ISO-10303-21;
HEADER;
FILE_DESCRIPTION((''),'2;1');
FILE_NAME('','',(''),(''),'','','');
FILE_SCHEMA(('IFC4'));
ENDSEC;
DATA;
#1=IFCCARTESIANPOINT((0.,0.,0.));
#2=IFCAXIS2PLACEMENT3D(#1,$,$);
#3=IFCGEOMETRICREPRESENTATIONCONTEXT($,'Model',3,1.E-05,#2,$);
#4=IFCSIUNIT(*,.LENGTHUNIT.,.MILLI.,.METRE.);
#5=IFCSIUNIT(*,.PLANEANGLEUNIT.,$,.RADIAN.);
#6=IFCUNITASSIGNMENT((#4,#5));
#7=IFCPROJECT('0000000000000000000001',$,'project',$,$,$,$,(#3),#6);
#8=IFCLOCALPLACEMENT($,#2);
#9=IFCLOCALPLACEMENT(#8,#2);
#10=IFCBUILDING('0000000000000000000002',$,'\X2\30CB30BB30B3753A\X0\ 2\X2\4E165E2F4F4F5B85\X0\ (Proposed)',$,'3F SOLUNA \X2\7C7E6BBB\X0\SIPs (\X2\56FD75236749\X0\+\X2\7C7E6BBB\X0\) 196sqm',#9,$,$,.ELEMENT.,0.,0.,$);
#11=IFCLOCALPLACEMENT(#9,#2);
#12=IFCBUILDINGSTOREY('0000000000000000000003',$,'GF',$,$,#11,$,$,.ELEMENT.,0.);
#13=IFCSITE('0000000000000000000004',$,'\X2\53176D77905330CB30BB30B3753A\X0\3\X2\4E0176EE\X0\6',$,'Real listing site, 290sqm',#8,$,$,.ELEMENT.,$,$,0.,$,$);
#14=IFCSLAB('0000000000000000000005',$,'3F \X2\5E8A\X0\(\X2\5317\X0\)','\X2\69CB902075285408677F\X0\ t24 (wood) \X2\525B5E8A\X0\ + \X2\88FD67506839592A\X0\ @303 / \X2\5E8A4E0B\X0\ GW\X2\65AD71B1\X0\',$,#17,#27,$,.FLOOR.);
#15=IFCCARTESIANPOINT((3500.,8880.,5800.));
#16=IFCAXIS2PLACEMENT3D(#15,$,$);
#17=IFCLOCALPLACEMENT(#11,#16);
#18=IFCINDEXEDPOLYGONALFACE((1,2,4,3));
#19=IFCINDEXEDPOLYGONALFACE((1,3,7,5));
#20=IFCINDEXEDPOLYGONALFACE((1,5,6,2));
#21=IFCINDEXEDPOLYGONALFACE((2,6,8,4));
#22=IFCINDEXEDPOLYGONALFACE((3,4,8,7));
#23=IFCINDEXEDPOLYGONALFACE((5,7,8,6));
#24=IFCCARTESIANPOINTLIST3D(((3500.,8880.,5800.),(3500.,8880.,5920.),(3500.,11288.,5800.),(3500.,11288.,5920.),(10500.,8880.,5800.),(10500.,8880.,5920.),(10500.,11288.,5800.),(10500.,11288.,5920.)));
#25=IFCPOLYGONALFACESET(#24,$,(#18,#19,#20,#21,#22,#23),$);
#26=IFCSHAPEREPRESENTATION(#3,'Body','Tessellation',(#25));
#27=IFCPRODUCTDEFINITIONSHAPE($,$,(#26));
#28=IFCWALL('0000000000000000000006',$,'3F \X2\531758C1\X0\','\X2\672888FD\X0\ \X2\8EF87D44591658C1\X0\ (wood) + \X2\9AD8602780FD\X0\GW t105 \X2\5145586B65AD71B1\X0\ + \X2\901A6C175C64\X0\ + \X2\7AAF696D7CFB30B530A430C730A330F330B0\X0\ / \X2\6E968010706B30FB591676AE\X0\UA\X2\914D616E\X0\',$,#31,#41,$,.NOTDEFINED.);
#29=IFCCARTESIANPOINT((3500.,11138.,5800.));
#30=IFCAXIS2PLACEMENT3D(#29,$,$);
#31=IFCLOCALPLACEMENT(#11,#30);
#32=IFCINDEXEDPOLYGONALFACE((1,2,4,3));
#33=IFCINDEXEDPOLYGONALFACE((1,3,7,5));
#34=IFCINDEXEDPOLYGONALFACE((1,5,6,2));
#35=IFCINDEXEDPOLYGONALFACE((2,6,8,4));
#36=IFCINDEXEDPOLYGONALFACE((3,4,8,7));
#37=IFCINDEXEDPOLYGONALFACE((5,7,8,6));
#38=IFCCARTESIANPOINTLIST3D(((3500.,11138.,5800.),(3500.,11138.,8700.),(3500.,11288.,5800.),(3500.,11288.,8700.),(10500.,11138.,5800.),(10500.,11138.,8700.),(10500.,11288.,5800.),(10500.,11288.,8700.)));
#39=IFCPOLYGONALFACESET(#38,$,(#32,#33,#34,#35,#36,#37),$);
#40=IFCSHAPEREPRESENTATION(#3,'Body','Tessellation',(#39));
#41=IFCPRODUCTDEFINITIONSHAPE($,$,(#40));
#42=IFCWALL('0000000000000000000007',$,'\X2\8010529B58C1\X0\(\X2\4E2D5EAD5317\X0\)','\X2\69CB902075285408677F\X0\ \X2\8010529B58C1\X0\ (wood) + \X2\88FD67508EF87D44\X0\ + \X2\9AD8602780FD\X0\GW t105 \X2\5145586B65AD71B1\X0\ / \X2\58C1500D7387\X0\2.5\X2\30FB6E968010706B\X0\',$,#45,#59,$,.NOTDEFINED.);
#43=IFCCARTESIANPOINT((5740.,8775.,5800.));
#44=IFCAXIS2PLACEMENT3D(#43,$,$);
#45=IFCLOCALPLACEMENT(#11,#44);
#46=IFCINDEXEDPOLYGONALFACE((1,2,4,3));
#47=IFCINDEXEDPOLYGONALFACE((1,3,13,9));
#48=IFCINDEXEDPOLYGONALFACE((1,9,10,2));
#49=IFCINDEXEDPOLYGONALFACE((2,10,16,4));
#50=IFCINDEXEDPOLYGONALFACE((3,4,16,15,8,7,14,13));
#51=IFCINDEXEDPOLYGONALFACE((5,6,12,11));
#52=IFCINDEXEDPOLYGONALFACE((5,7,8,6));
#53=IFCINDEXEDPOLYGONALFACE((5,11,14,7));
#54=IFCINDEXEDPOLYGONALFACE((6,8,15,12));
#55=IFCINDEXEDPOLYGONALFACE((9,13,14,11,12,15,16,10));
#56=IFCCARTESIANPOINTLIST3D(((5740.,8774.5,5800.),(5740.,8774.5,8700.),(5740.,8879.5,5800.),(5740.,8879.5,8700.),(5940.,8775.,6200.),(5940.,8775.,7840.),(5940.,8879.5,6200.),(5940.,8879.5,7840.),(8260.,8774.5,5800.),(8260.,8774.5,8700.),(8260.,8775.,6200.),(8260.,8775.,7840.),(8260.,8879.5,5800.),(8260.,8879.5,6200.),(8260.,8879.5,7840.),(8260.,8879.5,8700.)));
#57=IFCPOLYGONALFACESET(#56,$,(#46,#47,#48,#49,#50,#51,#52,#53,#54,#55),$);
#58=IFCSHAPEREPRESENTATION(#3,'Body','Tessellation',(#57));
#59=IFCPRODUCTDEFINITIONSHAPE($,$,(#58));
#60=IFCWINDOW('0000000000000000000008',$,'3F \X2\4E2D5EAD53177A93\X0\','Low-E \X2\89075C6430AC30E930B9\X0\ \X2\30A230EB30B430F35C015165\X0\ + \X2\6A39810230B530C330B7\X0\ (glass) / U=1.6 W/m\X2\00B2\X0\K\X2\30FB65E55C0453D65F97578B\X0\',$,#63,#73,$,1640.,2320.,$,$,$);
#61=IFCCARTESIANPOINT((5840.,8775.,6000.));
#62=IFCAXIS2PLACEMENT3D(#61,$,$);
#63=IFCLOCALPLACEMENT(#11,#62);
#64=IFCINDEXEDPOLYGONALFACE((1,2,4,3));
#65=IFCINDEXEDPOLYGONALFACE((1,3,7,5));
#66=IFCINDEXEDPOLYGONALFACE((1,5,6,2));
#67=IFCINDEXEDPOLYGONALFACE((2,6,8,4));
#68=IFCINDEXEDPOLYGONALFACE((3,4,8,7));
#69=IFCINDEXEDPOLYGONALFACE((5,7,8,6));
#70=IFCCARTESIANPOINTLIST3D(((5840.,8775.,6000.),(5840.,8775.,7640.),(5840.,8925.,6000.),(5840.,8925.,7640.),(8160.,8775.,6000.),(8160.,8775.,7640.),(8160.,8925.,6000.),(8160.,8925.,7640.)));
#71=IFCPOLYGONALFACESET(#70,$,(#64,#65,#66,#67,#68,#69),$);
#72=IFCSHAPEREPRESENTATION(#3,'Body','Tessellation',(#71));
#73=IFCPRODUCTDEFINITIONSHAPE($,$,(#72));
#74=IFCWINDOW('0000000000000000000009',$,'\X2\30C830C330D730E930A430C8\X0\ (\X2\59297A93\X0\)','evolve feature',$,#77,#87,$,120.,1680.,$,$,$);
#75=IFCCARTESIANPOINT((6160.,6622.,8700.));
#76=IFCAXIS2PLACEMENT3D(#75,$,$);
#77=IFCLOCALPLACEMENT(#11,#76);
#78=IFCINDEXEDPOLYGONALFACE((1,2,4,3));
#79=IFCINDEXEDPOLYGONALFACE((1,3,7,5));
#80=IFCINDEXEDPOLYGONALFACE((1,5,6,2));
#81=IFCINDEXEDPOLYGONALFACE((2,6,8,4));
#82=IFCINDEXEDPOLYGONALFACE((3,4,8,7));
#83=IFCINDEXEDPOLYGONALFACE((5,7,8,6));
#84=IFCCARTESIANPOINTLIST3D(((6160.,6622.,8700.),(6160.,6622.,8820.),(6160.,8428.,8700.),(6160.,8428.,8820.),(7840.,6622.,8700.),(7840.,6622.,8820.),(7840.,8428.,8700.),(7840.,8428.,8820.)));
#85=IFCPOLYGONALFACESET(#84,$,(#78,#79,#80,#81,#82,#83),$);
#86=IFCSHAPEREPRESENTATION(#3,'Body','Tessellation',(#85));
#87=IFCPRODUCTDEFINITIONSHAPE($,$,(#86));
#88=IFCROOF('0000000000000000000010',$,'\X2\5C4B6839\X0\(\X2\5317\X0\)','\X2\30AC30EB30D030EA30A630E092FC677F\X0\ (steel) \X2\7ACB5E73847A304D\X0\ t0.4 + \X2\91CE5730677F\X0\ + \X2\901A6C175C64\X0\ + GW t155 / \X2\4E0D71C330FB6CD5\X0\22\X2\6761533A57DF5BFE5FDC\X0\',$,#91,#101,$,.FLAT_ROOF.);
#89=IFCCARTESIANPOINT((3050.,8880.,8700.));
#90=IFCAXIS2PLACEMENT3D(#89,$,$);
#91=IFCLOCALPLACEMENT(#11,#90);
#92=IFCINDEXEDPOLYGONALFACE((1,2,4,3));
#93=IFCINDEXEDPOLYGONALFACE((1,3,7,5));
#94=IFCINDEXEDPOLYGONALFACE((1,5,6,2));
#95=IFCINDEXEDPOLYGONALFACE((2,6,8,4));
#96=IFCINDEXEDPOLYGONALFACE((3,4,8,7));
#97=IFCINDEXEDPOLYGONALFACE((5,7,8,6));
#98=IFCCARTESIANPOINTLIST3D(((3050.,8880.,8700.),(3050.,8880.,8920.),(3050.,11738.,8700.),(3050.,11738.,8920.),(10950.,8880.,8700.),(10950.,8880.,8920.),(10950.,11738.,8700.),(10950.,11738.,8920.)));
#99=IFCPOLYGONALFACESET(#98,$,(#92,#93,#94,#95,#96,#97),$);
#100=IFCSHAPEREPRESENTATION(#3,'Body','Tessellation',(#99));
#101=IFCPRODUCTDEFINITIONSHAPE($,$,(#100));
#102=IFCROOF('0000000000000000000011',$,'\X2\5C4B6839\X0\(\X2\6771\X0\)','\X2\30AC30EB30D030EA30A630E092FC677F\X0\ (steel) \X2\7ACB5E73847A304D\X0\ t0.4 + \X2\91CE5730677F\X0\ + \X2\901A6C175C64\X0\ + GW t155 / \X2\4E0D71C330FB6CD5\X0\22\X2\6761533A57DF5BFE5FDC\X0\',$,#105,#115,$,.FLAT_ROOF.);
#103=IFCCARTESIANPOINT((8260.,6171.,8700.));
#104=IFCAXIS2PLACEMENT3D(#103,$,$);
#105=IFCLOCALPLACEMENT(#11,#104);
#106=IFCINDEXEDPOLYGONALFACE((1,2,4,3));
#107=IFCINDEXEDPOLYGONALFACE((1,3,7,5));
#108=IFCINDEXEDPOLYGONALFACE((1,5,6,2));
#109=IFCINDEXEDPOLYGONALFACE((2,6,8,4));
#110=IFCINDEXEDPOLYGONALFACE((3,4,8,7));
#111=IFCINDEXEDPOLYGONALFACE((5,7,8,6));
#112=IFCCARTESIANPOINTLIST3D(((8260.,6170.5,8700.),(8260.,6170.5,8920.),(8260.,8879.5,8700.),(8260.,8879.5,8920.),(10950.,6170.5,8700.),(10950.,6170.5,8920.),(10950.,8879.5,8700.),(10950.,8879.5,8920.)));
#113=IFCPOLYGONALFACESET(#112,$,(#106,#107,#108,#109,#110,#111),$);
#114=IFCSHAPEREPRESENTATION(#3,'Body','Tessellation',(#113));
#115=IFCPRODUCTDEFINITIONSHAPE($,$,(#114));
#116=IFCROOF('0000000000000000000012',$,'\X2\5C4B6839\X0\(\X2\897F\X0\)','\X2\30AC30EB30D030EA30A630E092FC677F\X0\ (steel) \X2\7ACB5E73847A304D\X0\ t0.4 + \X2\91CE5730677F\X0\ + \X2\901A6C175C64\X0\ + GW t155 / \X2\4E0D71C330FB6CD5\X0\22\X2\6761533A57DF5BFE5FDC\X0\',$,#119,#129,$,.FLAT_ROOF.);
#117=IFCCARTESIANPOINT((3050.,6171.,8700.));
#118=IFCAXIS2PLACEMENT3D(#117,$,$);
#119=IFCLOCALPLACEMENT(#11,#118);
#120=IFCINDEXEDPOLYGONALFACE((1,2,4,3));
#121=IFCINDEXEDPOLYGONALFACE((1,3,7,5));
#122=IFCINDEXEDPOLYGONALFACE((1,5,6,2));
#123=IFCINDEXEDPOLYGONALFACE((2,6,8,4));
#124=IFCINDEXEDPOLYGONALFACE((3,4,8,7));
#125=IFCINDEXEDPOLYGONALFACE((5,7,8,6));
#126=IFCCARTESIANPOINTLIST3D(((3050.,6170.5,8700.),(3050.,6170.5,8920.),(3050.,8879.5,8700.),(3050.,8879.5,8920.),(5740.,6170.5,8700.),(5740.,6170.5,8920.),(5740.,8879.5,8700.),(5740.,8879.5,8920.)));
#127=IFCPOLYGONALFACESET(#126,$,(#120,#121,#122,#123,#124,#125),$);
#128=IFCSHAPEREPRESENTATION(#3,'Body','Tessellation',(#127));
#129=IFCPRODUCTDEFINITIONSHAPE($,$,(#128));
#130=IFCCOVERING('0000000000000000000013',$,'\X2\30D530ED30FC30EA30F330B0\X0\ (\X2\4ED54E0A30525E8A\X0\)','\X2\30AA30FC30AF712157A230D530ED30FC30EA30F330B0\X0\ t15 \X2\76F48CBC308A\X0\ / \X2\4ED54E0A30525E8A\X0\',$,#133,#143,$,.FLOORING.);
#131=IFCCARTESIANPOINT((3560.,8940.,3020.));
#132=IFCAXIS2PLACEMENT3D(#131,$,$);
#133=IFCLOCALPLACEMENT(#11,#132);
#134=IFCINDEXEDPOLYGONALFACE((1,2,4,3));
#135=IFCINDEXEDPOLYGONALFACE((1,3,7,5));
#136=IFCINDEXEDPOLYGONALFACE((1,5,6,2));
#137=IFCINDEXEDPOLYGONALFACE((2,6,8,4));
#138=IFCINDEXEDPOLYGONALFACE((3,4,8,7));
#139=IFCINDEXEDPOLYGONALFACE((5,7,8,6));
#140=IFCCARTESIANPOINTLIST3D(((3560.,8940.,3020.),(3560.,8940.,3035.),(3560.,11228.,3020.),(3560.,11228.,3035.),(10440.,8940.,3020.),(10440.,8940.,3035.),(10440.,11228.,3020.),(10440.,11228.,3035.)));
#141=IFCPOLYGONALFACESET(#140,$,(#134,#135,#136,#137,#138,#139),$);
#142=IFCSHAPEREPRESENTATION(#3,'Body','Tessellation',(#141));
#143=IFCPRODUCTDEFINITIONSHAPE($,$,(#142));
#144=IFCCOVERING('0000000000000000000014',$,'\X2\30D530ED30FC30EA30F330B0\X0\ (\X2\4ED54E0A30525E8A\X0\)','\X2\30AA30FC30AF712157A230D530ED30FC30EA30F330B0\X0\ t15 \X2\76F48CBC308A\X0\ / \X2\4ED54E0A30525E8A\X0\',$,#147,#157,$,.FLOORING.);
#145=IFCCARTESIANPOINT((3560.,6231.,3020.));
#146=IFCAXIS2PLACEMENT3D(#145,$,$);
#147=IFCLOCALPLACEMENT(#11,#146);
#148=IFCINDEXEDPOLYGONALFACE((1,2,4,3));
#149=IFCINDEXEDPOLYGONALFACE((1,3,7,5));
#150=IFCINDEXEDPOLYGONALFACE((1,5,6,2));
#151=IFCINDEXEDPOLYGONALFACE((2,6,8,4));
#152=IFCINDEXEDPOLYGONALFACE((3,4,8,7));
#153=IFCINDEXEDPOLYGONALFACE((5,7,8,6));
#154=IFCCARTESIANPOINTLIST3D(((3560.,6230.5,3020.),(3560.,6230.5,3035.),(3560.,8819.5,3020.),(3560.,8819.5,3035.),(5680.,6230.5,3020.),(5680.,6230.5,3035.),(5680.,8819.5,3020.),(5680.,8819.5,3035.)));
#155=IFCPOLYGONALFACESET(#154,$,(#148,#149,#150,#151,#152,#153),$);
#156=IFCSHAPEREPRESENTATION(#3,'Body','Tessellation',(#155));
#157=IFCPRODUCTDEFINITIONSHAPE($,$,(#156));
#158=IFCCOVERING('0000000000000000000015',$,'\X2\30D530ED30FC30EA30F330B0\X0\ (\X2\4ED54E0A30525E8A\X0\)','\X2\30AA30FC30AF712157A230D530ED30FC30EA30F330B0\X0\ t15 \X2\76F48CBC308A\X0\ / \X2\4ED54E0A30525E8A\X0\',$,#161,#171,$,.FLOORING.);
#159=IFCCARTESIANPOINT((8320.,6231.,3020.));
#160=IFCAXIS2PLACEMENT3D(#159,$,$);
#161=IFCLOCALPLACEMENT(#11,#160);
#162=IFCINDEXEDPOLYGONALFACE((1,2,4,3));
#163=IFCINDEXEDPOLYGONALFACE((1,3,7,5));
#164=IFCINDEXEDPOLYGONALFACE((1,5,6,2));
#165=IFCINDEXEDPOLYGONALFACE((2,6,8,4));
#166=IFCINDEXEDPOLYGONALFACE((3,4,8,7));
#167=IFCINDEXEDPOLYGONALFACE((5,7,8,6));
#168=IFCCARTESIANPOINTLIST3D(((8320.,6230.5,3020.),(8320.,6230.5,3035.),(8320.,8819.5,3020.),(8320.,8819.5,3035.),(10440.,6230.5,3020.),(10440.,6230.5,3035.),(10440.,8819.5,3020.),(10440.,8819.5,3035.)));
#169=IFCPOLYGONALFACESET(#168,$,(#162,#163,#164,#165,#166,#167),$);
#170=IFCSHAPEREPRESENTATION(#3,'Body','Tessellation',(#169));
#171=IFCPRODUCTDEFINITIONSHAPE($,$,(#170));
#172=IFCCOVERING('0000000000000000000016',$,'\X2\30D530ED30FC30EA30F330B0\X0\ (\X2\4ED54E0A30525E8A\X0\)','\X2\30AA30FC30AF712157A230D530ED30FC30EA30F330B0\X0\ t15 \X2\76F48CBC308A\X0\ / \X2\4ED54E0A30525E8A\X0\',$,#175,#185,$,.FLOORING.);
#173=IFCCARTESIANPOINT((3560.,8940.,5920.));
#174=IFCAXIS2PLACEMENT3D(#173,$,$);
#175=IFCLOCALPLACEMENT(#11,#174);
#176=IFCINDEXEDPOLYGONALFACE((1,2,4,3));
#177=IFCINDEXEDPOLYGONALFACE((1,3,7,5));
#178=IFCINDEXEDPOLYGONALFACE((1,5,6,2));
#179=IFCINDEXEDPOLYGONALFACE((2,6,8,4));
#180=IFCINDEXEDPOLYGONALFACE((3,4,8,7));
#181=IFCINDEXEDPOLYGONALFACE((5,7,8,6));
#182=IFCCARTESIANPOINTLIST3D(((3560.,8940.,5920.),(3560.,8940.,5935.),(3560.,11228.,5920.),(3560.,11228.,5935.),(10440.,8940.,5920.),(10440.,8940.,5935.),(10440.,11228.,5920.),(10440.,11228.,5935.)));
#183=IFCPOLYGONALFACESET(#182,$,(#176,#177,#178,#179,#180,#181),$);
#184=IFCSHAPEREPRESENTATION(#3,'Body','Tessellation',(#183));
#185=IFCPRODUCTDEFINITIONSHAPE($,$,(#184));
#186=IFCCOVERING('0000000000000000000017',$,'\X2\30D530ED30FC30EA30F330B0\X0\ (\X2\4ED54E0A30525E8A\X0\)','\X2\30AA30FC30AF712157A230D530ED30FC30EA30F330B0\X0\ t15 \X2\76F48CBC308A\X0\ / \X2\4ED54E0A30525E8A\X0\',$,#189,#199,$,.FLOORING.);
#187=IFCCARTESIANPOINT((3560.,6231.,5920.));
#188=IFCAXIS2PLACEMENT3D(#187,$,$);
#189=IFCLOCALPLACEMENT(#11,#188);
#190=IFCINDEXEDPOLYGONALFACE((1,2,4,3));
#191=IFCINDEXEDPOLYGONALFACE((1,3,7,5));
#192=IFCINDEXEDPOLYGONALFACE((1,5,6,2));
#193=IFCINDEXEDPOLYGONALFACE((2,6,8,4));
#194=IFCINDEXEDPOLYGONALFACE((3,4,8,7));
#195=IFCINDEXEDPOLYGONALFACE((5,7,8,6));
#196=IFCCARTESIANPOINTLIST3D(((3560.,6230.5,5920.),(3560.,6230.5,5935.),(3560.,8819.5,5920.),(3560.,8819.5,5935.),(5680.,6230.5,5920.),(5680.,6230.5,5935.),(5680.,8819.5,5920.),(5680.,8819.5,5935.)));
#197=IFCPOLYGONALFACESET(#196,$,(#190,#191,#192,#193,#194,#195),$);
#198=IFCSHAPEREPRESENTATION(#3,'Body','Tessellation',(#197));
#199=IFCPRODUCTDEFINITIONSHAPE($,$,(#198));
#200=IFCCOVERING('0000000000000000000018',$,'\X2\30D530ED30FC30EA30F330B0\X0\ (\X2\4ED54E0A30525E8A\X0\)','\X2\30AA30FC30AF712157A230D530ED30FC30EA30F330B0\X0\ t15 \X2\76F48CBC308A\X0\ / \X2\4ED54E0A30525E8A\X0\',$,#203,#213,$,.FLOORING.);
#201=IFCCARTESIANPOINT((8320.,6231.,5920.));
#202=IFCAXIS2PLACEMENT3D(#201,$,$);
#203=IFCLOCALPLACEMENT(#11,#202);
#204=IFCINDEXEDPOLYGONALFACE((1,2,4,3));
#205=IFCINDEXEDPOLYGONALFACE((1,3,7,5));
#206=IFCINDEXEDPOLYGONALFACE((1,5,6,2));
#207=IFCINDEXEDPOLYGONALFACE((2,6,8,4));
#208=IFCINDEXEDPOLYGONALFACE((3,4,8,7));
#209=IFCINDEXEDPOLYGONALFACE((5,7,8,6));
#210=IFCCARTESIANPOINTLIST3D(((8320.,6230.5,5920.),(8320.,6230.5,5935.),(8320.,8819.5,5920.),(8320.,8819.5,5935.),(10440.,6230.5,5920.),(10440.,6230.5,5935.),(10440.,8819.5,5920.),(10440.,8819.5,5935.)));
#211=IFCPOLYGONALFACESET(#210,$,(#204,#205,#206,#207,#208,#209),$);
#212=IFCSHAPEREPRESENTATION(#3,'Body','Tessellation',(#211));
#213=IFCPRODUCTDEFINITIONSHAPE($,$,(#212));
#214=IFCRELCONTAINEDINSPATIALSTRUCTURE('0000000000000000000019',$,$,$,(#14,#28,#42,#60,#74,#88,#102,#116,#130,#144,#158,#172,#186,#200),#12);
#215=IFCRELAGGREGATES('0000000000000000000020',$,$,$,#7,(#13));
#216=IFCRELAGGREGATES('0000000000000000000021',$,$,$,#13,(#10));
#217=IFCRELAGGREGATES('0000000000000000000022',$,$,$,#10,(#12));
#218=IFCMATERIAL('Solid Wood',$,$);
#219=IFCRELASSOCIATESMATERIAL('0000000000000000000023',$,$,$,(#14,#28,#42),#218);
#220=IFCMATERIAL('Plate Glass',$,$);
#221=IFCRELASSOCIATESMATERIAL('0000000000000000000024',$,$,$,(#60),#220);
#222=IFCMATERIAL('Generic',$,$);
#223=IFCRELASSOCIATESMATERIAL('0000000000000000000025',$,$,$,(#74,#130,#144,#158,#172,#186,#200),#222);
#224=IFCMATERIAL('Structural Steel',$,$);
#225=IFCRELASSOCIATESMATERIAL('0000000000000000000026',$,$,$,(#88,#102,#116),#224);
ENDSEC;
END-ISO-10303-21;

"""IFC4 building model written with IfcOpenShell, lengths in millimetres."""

from ifc_helpers import new_model, si_unit, frame, frame_2d, origin, place, context, project, spatial, rectangle, extrude, material, element, fill, save


model = new_model("IFC4")

# Units and contexts
model_context = context("Model", 3, precision=1e-05, world=origin())
ifc_project = project(units=[si_unit("LENGTHUNIT", "METRE", prefix="MILLI"), si_unit("PLANEANGLEUNIT", "RADIAN")], contexts=[model_context])

# Site, building, storey
site_placement = place(None, origin())
site = spatial("IfcSite", under=ifc_project, at=site_placement, Name="北海道ニセコ町3丁目6", ObjectType="Real listing site, 290sqm", CompositionType="ELEMENT", RefElevation=0.0)
building_placement = place(site_placement, origin())
building = spatial("IfcBuilding", under=site, at=building_placement, Name="ニセコ町 2世帯住宅 (Proposed)", ObjectType="3F SOLUNA 籾殻SIPs (国産杉+籾殻) 196sqm", CompositionType="ELEMENT", ElevationOfRefHeight=0.0, ElevationOfTerrain=0.0)
storey_placement = place(building_placement, origin())
storey = spatial("IfcBuildingStorey", under=building, at=storey_placement, Name="GF", CompositionType="ELEMENT", Elevation=0.0)

# Slab
ifc_material_1 = material(Name="Solid Wood")
slab_placement = place(storey_placement, frame((3500.0, 8880.0, 5800.0)))
element("IfcSlab", 1, at=slab_placement, inside=storey, material=ifc_material_1, Name="3F 床(北)", Description="構造用合板 t24 (wood) 剛床 + 製材根太 @303 / 床下 GW断熱", PredefinedType="FLOOR", context=model_context, shape_type="SweptSolid", body=[
    extrude(rectangle(XDim=7000.0, YDim=2408.0, at=frame_2d((3500.0, 1204.0))), frame((3500.0, 8880.0, 5800.0)), (0.0, 0.0, 1.0), 120.0),
])

# Wall
wall_1_placement = place(storey_placement, frame((3500.0, 11138.0, 5800.0)))
element("IfcWall", 2, at=wall_1_placement, inside=storey, material=ifc_material_1, Name="3F 北壁", Description="木製 軸組外壁 (wood) + 高性能GW t105 充填断熱 + 通気層 + 窯業系サイディング / 準耐火・外皮UA配慮", PredefinedType="NOTDEFINED", context=model_context, shape_type="SweptSolid", body=[
    extrude(rectangle(XDim=7000.0, YDim=150.0, at=frame_2d((3500.0, 75.0))), frame((3500.0, 11138.0, 5800.0)), (0.0, 0.0, 1.0), 2900.0),
])

# Wall, opening, window
wall_2_placement = place(storey_placement, frame((5740.0, 8775.0, 5800.0)))
wall_2 = element("IfcWall", 3, at=wall_2_placement, inside=storey, material=ifc_material_1, Name="耐力壁(中庭北)", Description="構造用合板 耐力壁 (wood) + 製材軸組 + 高性能GW t105 充填断熱 / 壁倍率2.5・準耐火", PredefinedType="NOTDEFINED", context=model_context, shape_type="SweptSolid", body=[
    extrude(rectangle(XDim=2520.0, YDim=105.0, at=frame_2d((1260.0, 52.0))), frame((5740.0, 8775.0, 5800.0)), (0.0, 0.0, 1.0), 2900.0),
])
opening_placement = place(storey_placement, frame((5840.0, 8775.0, 6000.0)))
opening = element("IfcOpeningElement", 4, at=opening_placement, cuts=wall_2, PredefinedType="NOTDEFINED", context=model_context, shape_type="SweptSolid", body=[
    extrude(rectangle(XDim=2320.0, YDim=150.0, at=frame_2d((1160.0, 75.0))), frame((5840.0, 8775.0, 6000.0)), (0.0, 0.0, 1.0), 1640.0),
])
ifc_material_2 = material(Name="Plate Glass")
window_1_placement = place(storey_placement, frame((5840.0, 8775.0, 6000.0)))
window_1 = element("IfcWindow", 5, at=window_1_placement, inside=storey, material=ifc_material_2, Name="3F 中庭北窓", Description="Low-E 複層ガラス アルゴン封入 + 樹脂サッシ (glass) / U=1.6 W/m²K・日射取得型", OverallHeight=1640.0, OverallWidth=2320.0, context=model_context, shape_type="SweptSolid", body=[
    extrude(rectangle(XDim=2320.0, YDim=150.0, at=frame_2d((1160.0, 75.0))), frame((5840.0, 8775.0, 6000.0)), (0.0, 0.0, 1.0), 1640.0),
])
fill(opening, window_1)

# Window
ifc_material_3 = material(Name="Generic")
window_2_placement = place(storey_placement, frame((6160.0, 6622.0, 8700.0)))
element("IfcWindow", 6, at=window_2_placement, inside=storey, material=ifc_material_3, Name="トップライト (天窓)", Description="evolve feature", OverallHeight=120.0, OverallWidth=1680.0, context=model_context, shape_type="SweptSolid", body=[
    extrude(rectangle(XDim=1680.0, YDim=1806.0, at=frame_2d((840.0, 903.0))), frame((6160.0, 6622.0, 8700.0)), (0.0, 0.0, 1.0), 120.0),
])

# Roofs
ifc_material_4 = material(Name="Structural Steel")
roof_1_placement = place(storey_placement, frame((3050.0, 8880.0, 8700.0)))
element("IfcRoof", 7, at=roof_1_placement, inside=storey, material=ifc_material_4, Name="屋根(北)", Description="ガルバリウム鋼板 (steel) 立平葺き t0.4 + 野地板 + 通気層 + GW t155 / 不燃・法22条区域対応", PredefinedType="FLAT_ROOF", context=model_context, shape_type="SweptSolid", body=[
    extrude(rectangle(XDim=7900.0, YDim=2858.0, at=frame_2d((3950.0, 1429.0))), frame((3050.0, 8880.0, 8700.0)), (0.0, 0.0, 1.0), 220.0),
])
roof_2_placement = place(storey_placement, frame((8260.0, 6171.0, 8700.0)))
element("IfcRoof", 8, at=roof_2_placement, inside=storey, material=ifc_material_4, Name="屋根(東)", Description="ガルバリウム鋼板 (steel) 立平葺き t0.4 + 野地板 + 通気層 + GW t155 / 不燃・法22条区域対応", PredefinedType="FLAT_ROOF", context=model_context, shape_type="SweptSolid", body=[
    extrude(rectangle(XDim=2690.0, YDim=2709.0, at=frame_2d((1345.0, 1354.0))), frame((8260.0, 6171.0, 8700.0)), (0.0, 0.0, 1.0), 220.0),
])
roof_3_placement = place(storey_placement, frame((3050.0, 6171.0, 8700.0)))
element("IfcRoof", 9, at=roof_3_placement, inside=storey, material=ifc_material_4, Name="屋根(西)", Description="ガルバリウム鋼板 (steel) 立平葺き t0.4 + 野地板 + 通気層 + GW t155 / 不燃・法22条区域対応", PredefinedType="FLAT_ROOF", context=model_context, shape_type="SweptSolid", body=[
    extrude(rectangle(XDim=2690.0, YDim=2709.0, at=frame_2d((1345.0, 1354.0))), frame((3050.0, 6171.0, 8700.0)), (0.0, 0.0, 1.0), 220.0),
])

# Coverings
covering_1_placement = place(storey_placement, frame((3560.0, 8940.0, 3020.0)))
element("IfcCovering", 10, at=covering_1_placement, inside=storey, material=ifc_material_3, Name="フローリング (仕上げ床)", Description="オーク無垢フローリング t15 直貼り / 仕上げ床", PredefinedType="FLOORING", context=model_context, shape_type="SweptSolid", body=[
    extrude(rectangle(XDim=6880.0, YDim=2288.0, at=frame_2d((3440.0, 1144.0))), frame((3560.0, 8940.0, 3020.0)), (0.0, 0.0, 1.0), 15.0),
])
covering_2_placement = place(storey_placement, frame((3560.0, 6231.0, 3020.0)))
element("IfcCovering", 11, at=covering_2_placement, inside=storey, material=ifc_material_3, Name="フローリング (仕上げ床)", Description="オーク無垢フローリング t15 直貼り / 仕上げ床", PredefinedType="FLOORING", context=model_context, shape_type="SweptSolid", body=[
    extrude(rectangle(XDim=2120.0, YDim=2589.0, at=frame_2d((1060.0, 1294.0))), frame((3560.0, 6231.0, 3020.0)), (0.0, 0.0, 1.0), 15.0),
])
covering_3_placement = place(storey_placement, frame((8320.0, 6231.0, 3020.0)))
element("IfcCovering", 12, at=covering_3_placement, inside=storey, material=ifc_material_3, Name="フローリング (仕上げ床)", Description="オーク無垢フローリング t15 直貼り / 仕上げ床", PredefinedType="FLOORING", context=model_context, shape_type="SweptSolid", body=[
    extrude(rectangle(XDim=2120.0, YDim=2589.0, at=frame_2d((1060.0, 1294.0))), frame((8320.0, 6231.0, 3020.0)), (0.0, 0.0, 1.0), 15.0),
])
covering_4_placement = place(storey_placement, frame((3560.0, 8940.0, 5920.0)))
element("IfcCovering", 13, at=covering_4_placement, inside=storey, material=ifc_material_3, Name="フローリング (仕上げ床)", Description="オーク無垢フローリング t15 直貼り / 仕上げ床", PredefinedType="FLOORING", context=model_context, shape_type="SweptSolid", body=[
    extrude(rectangle(XDim=6880.0, YDim=2288.0, at=frame_2d((3440.0, 1144.0))), frame((3560.0, 8940.0, 5920.0)), (0.0, 0.0, 1.0), 15.0),
])
covering_5_placement = place(storey_placement, frame((3560.0, 6231.0, 5920.0)))
element("IfcCovering", 14, at=covering_5_placement, inside=storey, material=ifc_material_3, Name="フローリング (仕上げ床)", Description="オーク無垢フローリング t15 直貼り / 仕上げ床", PredefinedType="FLOORING", context=model_context, shape_type="SweptSolid", body=[
    extrude(rectangle(XDim=2120.0, YDim=2589.0, at=frame_2d((1060.0, 1294.0))), frame((3560.0, 6231.0, 5920.0)), (0.0, 0.0, 1.0), 15.0),
])
covering_6_placement = place(storey_placement, frame((8320.0, 6231.0, 5920.0)))
element("IfcCovering", 15, at=covering_6_placement, inside=storey, material=ifc_material_3, Name="フローリング (仕上げ床)", Description="オーク無垢フローリング t15 直貼り / 仕上げ床", PredefinedType="FLOORING", context=model_context, shape_type="SweptSolid", body=[
    extrude(rectangle(XDim=2120.0, YDim=2589.0, at=frame_2d((1060.0, 1294.0))), frame((8320.0, 6231.0, 5920.0)), (0.0, 0.0, 1.0), 15.0),
])

save(model, "model.ifc")
